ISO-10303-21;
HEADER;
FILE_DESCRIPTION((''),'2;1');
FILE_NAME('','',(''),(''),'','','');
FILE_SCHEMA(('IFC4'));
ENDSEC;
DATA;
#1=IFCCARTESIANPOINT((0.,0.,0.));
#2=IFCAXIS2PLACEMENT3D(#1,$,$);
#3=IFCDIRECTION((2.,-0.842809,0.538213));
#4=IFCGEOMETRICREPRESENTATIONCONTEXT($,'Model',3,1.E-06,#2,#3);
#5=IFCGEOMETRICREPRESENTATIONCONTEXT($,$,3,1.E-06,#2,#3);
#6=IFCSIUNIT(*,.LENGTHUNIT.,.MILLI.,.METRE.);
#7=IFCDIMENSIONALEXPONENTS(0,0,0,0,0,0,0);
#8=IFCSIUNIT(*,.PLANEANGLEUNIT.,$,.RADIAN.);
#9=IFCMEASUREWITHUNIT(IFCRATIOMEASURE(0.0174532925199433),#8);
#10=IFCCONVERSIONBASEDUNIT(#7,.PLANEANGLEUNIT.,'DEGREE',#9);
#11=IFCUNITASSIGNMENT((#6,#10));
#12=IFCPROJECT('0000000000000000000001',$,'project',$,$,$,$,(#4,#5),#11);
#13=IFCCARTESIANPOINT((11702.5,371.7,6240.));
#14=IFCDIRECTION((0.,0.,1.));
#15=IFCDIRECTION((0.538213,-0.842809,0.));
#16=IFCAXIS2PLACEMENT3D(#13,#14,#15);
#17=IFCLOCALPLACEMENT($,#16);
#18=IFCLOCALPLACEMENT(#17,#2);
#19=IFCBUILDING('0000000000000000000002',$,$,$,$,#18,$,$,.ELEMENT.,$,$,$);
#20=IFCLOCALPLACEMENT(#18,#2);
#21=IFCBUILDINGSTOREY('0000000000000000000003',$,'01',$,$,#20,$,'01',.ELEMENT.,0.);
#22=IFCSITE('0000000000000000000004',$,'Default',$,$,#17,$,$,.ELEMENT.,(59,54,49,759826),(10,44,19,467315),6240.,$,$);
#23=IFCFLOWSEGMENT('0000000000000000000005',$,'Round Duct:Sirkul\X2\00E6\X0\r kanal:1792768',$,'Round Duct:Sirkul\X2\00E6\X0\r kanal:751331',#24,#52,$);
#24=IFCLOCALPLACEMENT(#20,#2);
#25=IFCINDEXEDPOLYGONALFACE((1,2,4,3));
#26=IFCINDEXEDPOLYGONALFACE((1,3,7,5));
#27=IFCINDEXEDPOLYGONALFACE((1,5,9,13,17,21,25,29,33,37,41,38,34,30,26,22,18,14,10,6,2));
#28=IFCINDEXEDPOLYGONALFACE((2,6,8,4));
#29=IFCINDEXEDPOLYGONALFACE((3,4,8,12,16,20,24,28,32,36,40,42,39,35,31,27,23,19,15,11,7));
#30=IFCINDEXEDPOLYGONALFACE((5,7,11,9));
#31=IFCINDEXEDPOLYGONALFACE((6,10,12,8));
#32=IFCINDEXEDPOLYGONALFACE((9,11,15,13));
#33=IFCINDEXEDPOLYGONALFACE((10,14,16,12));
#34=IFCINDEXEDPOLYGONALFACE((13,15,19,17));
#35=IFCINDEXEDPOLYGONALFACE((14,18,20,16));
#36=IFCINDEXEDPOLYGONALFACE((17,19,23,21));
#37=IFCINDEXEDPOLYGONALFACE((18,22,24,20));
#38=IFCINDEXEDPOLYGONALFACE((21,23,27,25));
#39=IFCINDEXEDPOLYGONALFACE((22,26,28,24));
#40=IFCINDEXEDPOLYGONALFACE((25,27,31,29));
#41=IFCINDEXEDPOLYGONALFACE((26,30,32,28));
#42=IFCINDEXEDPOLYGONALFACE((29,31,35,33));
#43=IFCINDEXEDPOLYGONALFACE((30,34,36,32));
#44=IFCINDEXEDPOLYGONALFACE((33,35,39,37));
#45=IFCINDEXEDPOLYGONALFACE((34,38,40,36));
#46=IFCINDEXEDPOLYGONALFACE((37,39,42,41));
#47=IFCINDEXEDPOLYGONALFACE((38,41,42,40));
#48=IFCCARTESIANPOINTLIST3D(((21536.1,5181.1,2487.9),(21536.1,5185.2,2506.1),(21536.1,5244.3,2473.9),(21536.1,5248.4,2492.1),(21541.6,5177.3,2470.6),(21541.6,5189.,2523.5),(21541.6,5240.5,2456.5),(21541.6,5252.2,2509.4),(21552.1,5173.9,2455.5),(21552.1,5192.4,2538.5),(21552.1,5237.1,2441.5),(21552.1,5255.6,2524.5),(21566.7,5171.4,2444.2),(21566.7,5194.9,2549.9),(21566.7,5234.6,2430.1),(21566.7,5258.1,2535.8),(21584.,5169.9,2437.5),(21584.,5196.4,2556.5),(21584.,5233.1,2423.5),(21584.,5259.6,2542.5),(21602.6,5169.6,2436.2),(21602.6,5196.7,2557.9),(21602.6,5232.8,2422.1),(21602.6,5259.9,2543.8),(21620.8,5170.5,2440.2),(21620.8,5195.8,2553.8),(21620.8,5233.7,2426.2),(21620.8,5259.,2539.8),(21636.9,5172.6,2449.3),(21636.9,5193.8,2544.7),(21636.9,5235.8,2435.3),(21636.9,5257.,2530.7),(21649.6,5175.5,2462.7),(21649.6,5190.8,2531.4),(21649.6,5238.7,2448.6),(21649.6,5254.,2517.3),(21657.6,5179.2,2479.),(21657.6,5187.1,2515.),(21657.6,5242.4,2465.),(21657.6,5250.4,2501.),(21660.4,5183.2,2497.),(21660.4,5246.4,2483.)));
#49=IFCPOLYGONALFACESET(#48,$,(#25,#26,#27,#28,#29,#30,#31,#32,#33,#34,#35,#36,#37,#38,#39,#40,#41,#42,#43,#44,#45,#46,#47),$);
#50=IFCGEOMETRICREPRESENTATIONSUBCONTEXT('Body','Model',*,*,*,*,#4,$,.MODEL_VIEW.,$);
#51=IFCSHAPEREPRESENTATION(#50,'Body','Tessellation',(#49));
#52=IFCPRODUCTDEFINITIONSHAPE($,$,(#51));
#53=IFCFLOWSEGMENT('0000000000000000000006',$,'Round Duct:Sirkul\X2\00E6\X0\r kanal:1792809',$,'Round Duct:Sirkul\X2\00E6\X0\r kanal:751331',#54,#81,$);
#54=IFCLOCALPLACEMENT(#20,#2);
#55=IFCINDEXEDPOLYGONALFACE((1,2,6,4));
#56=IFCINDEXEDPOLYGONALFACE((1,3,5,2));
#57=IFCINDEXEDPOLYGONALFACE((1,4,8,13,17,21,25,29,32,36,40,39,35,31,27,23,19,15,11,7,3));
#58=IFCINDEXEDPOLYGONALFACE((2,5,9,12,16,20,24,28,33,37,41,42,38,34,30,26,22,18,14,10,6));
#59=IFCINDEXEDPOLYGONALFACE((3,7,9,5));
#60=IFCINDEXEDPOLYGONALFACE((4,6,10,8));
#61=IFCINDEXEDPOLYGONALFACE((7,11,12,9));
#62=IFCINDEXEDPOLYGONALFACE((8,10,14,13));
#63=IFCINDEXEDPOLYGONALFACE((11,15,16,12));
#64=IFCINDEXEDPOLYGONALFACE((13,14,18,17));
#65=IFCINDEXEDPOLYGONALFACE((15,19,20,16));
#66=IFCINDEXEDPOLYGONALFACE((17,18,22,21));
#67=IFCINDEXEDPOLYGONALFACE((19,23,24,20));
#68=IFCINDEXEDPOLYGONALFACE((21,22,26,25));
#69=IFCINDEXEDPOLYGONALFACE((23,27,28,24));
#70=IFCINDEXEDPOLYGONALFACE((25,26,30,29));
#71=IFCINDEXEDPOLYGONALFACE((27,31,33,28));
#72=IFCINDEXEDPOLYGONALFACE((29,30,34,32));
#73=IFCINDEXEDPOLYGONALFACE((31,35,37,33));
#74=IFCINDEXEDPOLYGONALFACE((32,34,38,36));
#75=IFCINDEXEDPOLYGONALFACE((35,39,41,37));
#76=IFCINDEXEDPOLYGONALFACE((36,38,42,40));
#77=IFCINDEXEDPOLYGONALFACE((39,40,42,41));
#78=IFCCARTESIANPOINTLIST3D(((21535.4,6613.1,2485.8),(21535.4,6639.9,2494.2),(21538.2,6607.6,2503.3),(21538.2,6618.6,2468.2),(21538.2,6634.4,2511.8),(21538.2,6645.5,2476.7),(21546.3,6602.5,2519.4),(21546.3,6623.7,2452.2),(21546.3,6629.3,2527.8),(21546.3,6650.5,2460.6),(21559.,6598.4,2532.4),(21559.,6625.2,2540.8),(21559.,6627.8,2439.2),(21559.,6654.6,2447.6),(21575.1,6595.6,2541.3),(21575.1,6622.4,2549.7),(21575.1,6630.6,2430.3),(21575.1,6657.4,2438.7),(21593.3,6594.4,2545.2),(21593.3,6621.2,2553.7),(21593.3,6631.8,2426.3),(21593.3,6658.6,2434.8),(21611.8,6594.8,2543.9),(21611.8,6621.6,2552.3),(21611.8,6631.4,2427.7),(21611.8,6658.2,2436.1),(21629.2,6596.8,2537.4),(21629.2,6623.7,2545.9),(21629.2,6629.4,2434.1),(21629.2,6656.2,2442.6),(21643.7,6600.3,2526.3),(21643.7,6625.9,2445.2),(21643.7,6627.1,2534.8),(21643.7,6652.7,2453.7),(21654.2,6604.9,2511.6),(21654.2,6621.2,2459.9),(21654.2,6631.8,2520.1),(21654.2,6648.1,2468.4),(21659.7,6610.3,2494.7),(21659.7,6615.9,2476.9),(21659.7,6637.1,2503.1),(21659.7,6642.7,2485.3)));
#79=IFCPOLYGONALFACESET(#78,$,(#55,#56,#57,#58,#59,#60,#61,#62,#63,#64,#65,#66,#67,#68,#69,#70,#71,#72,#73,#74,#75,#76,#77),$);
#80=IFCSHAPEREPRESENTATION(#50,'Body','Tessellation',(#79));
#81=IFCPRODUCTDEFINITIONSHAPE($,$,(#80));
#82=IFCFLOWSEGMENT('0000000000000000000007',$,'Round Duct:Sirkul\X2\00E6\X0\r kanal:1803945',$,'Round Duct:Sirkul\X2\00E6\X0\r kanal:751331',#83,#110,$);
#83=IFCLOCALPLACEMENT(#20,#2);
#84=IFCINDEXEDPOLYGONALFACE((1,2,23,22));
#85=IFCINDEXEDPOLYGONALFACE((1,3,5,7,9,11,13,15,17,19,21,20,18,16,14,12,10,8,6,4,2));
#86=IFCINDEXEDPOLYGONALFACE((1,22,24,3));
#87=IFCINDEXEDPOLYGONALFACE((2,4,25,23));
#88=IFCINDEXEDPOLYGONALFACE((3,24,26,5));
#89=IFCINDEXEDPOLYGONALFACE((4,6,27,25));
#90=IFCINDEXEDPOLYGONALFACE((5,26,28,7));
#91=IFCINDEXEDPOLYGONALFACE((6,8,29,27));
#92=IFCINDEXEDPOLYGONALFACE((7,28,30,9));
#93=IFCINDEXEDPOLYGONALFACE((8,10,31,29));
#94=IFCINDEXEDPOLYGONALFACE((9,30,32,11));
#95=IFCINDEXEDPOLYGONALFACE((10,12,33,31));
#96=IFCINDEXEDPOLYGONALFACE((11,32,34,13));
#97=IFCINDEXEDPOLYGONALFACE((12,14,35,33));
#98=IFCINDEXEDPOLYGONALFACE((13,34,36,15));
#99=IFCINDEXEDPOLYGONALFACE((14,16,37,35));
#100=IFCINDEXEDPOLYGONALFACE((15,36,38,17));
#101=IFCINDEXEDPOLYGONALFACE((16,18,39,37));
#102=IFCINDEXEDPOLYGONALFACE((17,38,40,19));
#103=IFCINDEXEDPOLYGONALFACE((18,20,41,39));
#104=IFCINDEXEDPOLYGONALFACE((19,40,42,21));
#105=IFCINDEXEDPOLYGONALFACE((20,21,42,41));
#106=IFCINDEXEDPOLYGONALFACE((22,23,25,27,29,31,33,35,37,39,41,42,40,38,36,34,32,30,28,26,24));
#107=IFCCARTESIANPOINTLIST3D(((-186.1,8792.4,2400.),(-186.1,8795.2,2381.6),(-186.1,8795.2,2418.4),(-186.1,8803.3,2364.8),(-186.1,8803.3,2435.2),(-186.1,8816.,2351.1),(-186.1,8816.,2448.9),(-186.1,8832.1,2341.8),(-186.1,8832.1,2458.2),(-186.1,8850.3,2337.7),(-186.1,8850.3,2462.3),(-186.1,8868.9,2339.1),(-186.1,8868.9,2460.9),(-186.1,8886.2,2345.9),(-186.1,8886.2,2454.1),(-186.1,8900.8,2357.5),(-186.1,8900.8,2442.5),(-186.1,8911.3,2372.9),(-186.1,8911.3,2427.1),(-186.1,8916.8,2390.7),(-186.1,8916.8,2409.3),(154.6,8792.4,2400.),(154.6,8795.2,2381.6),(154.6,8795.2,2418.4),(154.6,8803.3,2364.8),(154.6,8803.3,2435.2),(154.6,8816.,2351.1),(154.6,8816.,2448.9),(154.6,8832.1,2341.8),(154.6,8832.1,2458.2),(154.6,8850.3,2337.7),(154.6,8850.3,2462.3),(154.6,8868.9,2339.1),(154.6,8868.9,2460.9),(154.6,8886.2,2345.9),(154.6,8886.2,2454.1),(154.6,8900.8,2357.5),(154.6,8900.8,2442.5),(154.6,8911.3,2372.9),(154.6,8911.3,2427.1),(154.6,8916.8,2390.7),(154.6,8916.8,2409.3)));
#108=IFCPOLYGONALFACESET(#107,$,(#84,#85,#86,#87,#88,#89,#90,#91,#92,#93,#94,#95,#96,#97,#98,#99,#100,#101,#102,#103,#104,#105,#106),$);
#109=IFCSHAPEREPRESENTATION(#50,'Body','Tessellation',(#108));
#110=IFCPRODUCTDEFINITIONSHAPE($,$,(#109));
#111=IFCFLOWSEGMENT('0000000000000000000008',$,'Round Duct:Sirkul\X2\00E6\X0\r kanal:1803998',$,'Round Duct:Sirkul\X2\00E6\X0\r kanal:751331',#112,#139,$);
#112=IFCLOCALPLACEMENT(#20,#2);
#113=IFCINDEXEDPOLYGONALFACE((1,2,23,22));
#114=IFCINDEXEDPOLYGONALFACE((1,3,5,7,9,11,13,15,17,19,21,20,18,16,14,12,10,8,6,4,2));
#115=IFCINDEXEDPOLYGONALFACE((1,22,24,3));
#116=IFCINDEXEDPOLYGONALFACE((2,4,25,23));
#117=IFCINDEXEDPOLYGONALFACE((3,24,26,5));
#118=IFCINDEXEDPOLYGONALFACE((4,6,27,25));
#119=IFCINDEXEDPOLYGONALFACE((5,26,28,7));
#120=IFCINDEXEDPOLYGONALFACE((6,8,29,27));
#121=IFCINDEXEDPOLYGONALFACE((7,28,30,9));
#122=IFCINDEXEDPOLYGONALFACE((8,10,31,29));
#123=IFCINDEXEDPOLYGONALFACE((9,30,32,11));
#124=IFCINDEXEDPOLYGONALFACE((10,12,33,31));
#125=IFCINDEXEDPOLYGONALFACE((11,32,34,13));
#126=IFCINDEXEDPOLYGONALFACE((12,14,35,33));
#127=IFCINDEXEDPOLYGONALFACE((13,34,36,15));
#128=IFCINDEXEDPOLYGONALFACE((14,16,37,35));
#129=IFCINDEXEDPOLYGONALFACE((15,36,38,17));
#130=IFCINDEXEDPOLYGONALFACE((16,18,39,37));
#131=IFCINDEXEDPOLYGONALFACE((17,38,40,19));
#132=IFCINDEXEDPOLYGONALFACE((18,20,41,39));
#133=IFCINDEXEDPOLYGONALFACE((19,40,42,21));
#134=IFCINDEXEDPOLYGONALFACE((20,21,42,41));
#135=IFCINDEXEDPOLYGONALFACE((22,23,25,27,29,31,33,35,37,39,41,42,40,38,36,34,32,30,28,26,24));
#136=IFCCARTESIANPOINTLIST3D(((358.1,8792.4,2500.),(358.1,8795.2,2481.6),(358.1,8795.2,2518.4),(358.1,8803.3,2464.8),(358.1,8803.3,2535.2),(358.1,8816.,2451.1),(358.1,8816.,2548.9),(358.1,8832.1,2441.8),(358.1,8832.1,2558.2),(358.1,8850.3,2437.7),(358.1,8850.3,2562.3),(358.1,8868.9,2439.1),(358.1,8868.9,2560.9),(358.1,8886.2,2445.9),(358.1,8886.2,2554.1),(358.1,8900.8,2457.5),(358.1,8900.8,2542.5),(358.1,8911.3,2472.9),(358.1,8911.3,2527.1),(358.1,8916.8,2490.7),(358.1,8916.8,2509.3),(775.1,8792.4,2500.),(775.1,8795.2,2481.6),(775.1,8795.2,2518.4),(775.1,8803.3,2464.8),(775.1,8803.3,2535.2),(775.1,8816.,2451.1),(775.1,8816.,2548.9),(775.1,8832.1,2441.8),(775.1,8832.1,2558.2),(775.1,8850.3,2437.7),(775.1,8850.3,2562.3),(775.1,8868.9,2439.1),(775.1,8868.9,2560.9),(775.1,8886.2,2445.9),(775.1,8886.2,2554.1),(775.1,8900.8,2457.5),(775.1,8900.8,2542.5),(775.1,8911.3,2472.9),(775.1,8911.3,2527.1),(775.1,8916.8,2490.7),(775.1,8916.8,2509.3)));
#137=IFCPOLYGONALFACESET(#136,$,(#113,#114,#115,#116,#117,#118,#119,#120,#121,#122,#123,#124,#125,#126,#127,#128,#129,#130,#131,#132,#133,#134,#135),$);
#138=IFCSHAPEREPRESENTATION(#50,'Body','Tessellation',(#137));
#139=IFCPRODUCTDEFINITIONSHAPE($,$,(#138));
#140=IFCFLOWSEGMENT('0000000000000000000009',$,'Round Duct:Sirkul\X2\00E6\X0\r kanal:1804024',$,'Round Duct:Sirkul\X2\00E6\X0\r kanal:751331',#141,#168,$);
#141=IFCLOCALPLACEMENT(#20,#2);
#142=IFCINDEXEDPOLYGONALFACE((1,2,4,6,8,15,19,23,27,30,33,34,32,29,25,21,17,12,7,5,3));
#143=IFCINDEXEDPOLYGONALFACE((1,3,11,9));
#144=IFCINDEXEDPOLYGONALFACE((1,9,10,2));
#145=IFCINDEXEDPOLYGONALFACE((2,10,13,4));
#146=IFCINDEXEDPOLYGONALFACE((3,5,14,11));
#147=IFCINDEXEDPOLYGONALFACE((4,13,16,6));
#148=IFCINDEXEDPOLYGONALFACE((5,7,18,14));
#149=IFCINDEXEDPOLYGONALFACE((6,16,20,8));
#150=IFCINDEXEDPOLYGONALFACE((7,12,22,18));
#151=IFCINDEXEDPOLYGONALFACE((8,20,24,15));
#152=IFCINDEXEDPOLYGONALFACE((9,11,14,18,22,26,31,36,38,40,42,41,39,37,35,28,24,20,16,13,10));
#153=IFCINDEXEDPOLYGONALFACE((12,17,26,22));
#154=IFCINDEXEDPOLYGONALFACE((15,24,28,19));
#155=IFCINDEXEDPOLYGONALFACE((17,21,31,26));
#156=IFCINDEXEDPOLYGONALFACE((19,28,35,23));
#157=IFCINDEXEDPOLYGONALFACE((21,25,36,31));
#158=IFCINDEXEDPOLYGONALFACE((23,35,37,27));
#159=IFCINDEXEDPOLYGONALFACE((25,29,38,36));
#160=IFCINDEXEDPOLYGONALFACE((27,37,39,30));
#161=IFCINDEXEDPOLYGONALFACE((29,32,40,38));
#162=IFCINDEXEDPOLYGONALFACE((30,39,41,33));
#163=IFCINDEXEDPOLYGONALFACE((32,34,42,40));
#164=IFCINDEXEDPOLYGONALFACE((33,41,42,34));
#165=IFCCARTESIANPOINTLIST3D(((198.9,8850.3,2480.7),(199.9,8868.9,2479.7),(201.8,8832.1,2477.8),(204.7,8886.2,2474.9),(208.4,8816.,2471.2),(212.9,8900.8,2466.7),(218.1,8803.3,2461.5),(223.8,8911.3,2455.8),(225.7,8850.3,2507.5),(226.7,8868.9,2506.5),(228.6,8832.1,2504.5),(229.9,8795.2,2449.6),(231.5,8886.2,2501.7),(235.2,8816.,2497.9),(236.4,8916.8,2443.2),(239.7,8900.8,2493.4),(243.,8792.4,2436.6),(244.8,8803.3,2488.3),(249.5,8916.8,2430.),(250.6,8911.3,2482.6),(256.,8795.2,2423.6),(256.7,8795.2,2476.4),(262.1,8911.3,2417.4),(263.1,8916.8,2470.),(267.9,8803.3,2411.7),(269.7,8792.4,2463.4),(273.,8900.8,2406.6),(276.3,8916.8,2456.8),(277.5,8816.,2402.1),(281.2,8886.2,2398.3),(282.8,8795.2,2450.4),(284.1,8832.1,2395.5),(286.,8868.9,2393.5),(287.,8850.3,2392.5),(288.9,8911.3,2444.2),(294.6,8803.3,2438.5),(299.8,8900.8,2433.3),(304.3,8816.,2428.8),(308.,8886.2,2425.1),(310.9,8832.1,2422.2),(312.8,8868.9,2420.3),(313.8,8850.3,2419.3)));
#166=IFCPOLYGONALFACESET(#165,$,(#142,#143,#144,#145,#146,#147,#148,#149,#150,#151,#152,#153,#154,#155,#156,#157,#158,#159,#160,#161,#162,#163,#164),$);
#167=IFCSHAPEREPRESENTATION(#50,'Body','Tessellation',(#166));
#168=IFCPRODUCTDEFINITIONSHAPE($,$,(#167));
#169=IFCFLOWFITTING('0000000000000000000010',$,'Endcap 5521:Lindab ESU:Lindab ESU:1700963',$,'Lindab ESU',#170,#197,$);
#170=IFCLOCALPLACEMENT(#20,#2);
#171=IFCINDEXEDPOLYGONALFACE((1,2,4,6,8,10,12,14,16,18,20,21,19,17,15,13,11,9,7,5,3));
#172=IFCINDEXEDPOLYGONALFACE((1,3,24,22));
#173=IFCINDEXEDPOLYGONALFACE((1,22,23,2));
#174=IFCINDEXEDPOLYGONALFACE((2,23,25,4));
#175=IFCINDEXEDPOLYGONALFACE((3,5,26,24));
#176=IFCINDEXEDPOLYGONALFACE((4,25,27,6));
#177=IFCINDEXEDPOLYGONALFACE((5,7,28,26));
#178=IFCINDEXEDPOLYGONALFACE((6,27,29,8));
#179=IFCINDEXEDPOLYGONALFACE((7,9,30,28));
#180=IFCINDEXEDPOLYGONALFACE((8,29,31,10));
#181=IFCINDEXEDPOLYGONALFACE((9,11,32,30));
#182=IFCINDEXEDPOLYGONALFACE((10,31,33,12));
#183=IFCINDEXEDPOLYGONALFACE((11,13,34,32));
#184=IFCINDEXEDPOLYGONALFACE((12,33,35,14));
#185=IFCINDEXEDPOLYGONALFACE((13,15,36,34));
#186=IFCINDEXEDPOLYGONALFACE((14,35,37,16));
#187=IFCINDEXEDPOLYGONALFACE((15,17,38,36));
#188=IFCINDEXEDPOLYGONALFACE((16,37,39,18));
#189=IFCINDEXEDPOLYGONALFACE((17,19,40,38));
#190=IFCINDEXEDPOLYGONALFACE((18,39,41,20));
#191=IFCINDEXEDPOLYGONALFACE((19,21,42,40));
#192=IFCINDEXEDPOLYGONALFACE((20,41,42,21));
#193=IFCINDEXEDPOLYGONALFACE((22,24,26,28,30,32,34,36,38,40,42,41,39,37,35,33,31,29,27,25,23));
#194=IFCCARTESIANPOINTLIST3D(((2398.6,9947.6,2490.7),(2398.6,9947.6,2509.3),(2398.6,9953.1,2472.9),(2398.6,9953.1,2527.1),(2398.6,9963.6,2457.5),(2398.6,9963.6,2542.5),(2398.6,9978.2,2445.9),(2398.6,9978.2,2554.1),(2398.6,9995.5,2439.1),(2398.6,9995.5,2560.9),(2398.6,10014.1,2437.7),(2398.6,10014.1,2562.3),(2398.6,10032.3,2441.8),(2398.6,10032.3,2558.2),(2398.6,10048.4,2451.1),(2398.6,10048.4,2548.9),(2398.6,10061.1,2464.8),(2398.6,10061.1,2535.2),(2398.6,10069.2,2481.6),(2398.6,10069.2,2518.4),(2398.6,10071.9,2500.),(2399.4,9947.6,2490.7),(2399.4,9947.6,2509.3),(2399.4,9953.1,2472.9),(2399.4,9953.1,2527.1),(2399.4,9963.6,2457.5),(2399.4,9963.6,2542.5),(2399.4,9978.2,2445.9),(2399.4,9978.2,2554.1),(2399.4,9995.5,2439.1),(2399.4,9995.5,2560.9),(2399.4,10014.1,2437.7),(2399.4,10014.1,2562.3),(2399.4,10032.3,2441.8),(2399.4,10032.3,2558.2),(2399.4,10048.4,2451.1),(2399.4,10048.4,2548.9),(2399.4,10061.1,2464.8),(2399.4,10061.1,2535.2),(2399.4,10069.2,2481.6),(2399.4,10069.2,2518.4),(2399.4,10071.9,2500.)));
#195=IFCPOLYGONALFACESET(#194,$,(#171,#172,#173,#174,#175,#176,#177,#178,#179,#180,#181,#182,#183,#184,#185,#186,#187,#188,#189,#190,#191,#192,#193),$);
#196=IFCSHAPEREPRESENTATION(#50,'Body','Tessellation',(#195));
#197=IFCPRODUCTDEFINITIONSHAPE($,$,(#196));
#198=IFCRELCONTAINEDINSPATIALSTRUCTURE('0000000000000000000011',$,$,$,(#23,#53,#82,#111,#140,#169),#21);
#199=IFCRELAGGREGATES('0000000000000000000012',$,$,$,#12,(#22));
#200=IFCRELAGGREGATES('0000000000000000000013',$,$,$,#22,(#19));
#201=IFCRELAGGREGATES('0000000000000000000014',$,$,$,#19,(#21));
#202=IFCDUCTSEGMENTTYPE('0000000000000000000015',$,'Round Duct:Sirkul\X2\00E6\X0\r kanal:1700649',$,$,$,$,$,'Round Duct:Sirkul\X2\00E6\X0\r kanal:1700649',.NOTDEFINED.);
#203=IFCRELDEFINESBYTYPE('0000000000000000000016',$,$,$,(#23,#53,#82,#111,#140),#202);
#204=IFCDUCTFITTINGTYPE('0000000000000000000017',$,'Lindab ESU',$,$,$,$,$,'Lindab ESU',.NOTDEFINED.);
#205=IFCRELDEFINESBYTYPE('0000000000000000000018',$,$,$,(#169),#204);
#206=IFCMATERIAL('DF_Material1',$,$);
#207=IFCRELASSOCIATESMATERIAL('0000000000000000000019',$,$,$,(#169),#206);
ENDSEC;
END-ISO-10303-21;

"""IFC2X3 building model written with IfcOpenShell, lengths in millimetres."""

from ifc_helpers import new_model, entity, si_unit, converted_unit, direction, frame, frame_2d, origin, origin_2d_with_axis, place, context, subcontext, project, spatial, circle, extrude, source, transform, mapped, material, type_object, type_shapes, element, save


model = new_model("IFC2X3")

# Units and contexts
model_context = context("Model", 3, precision=1e-06, world=origin(), true_north=direction((2.0, -0.842809, 0.538213)))
context_of_model = context(None, 3, precision=1e-06, world=origin(), true_north=direction((2.0, -0.842809, 0.538213)))
body_context = subcontext(model_context, "Body", "Model", "MODEL_VIEW")
ifc_project = project(units=[si_unit("LENGTHUNIT", "METRE", prefix="MILLI"), converted_unit("PLANEANGLEUNIT", "DEGREE", entity("IfcRatioMeasure", 0.0174532925199433), si_unit("PLANEANGLEUNIT", "RADIAN"), dimensions=[0, 0, 0, 0, 0, 0, 0])], contexts=[model_context, context_of_model])

# Site, building, storey
site_placement = place(None, frame((11702.5, 371.7, 6240.0), z_axis=(0.0, 0.0, 1.0), x_axis=(0.538213, -0.842809, 0.0)))
site = spatial("IfcSite", under=ifc_project, at=site_placement, Name="Default", CompositionType="ELEMENT", RefLatitude=(59, 54, 49, 759826), RefLongitude=(10, 44, 19, 467315), RefElevation=6240.0)
building_placement = place(site_placement, origin())
building = spatial("IfcBuilding", under=site, at=building_placement, CompositionType="ELEMENT")
storey_placement = place(building_placement, origin())
storey = spatial("IfcBuildingStorey", under=building, at=storey_placement, Name="01", LongName="01", CompositionType="ELEMENT", Elevation=0.0)

# Flow segments
duct_segment_type = type_object("IfcDuctSegmentType", Name="Round Duct:Sirkulær kanal:1700649", ElementType="Round Duct:Sirkulær kanal:1700649", PredefinedType="NOTDEFINED")
flow_segment_1_placement = place(storey_placement, origin())
element("IfcFlowSegment", 1, at=flow_segment_1_placement, inside=storey, type_object=duct_segment_type, Name="Round Duct:Sirkulær kanal:1792768", ObjectType="Round Duct:Sirkulær kanal:751331", context=body_context, shape_type="SweptSolid", body=[
    extrude(circle(Radius=62.5, at=frame_2d((0.0, 0.0), x_axis=(1.0, 0.0))), frame((21597.9, 5246.4, 2483.0), z_axis=(0.0, -0.976187, 0.21693), x_axis=(1.0, 0.0, 0.0)), (0.0, 0.0, 1.0), 64.8),
])
flow_segment_2_placement = place(storey_placement, origin())
element("IfcFlowSegment", 2, at=flow_segment_2_placement, inside=storey, type_object=duct_segment_type, Name="Round Duct:Sirkulær kanal:1792809", ObjectType="Round Duct:Sirkulær kanal:751331", context=body_context, shape_type="SweptSolid", body=[
    extrude(circle(Radius=62.5, at=frame_2d((0.0, 0.0), x_axis=(1.0, 0.0))), frame((21597.9, 6613.1, 2485.8), z_axis=(0.0, 0.9538, 0.300442), x_axis=(-1.0, 0.0, 0.0)), (0.0, 0.0, 1.0), 28.1),
])
flow_segment_3_placement = place(storey_placement, origin())
element("IfcFlowSegment", 3, at=flow_segment_3_placement, inside=storey, type_object=duct_segment_type, Name="Round Duct:Sirkulær kanal:1803945", ObjectType="Round Duct:Sirkulær kanal:751331", context=body_context, shape_type="SweptSolid", body=[
    extrude(circle(Radius=62.5, at=origin_2d_with_axis()), frame((-186.1, 8854.9, 2400.0), z_axis=(1.0, 0.0, 0.0), x_axis=(0.0, -1.0, 0.0)), (0.0, 0.0, 1.0), 340.7),
])
flow_segment_4_placement = place(storey_placement, origin())
element("IfcFlowSegment", 4, at=flow_segment_4_placement, inside=storey, type_object=duct_segment_type, Name="Round Duct:Sirkulær kanal:1803998", ObjectType="Round Duct:Sirkulær kanal:751331", context=body_context, shape_type="SweptSolid", body=[
    extrude(circle(Radius=62.5, at=origin_2d_with_axis()), frame((358.1, 8854.9, 2500.0), z_axis=(1.0, 0.0, 0.0), x_axis=(0.0, -1.0, 0.0)), (0.0, 0.0, 1.0), 416.9),
])
flow_segment_5_placement = place(storey_placement, origin())
element("IfcFlowSegment", 5, at=flow_segment_5_placement, inside=storey, type_object=duct_segment_type, Name="Round Duct:Sirkulær kanal:1804024", ObjectType="Round Duct:Sirkulær kanal:751331", context=body_context, shape_type="SweptSolid", body=[
    extrude(circle(Radius=62.5, at=frame_2d((0.0, 0.0), x_axis=(1.0, 0.0))), frame((243.0, 8854.9, 2436.6), z_axis=(0.707107, 0.0, 0.707107), x_axis=(0.0, -1.0, 0.0)), (0.0, 0.0, 1.0), 37.9),
])

# Flow fitting
ifc_material = material(Name="DF_Material1")
duct_fitting_type_1 = type_object("IfcDuctFittingType", Name="Lindab ESU", ElementType="Lindab ESU", PredefinedType="NOTDEFINED")
shared_shape_1 = source(origin(), body_context, "Body", "SweptSolid", [
    extrude(circle(Radius=62.5, at=frame_2d((0.0, 0.0), x_axis=(1.0, 0.0))), frame((0.0, 0.0, 0.0), z_axis=(1.0, 0.0, 0.0), x_axis=(0.0, 1.0, 0.0)), (0.0, 0.0, 1.0), 0.8),
])
type_shapes(duct_fitting_type_1, [shared_shape_1])
flow_fitting_1_placement = place(storey_placement, frame((2398.6, 10009.4, 2500.0)))
element("IfcFlowFitting", 6, at=flow_fitting_1_placement, inside=storey, type_object=duct_fitting_type_1, material=ifc_material, Name="Endcap 5521:Lindab ESU:Lindab ESU:1700963", ObjectType="Lindab ESU", context=body_context, shape_type="MappedRepresentation", body=[
    mapped(shared_shape_1, transform((0.0, 0.0, 0.0), scale=1.0)),
])

save(model, "model.ifc")
